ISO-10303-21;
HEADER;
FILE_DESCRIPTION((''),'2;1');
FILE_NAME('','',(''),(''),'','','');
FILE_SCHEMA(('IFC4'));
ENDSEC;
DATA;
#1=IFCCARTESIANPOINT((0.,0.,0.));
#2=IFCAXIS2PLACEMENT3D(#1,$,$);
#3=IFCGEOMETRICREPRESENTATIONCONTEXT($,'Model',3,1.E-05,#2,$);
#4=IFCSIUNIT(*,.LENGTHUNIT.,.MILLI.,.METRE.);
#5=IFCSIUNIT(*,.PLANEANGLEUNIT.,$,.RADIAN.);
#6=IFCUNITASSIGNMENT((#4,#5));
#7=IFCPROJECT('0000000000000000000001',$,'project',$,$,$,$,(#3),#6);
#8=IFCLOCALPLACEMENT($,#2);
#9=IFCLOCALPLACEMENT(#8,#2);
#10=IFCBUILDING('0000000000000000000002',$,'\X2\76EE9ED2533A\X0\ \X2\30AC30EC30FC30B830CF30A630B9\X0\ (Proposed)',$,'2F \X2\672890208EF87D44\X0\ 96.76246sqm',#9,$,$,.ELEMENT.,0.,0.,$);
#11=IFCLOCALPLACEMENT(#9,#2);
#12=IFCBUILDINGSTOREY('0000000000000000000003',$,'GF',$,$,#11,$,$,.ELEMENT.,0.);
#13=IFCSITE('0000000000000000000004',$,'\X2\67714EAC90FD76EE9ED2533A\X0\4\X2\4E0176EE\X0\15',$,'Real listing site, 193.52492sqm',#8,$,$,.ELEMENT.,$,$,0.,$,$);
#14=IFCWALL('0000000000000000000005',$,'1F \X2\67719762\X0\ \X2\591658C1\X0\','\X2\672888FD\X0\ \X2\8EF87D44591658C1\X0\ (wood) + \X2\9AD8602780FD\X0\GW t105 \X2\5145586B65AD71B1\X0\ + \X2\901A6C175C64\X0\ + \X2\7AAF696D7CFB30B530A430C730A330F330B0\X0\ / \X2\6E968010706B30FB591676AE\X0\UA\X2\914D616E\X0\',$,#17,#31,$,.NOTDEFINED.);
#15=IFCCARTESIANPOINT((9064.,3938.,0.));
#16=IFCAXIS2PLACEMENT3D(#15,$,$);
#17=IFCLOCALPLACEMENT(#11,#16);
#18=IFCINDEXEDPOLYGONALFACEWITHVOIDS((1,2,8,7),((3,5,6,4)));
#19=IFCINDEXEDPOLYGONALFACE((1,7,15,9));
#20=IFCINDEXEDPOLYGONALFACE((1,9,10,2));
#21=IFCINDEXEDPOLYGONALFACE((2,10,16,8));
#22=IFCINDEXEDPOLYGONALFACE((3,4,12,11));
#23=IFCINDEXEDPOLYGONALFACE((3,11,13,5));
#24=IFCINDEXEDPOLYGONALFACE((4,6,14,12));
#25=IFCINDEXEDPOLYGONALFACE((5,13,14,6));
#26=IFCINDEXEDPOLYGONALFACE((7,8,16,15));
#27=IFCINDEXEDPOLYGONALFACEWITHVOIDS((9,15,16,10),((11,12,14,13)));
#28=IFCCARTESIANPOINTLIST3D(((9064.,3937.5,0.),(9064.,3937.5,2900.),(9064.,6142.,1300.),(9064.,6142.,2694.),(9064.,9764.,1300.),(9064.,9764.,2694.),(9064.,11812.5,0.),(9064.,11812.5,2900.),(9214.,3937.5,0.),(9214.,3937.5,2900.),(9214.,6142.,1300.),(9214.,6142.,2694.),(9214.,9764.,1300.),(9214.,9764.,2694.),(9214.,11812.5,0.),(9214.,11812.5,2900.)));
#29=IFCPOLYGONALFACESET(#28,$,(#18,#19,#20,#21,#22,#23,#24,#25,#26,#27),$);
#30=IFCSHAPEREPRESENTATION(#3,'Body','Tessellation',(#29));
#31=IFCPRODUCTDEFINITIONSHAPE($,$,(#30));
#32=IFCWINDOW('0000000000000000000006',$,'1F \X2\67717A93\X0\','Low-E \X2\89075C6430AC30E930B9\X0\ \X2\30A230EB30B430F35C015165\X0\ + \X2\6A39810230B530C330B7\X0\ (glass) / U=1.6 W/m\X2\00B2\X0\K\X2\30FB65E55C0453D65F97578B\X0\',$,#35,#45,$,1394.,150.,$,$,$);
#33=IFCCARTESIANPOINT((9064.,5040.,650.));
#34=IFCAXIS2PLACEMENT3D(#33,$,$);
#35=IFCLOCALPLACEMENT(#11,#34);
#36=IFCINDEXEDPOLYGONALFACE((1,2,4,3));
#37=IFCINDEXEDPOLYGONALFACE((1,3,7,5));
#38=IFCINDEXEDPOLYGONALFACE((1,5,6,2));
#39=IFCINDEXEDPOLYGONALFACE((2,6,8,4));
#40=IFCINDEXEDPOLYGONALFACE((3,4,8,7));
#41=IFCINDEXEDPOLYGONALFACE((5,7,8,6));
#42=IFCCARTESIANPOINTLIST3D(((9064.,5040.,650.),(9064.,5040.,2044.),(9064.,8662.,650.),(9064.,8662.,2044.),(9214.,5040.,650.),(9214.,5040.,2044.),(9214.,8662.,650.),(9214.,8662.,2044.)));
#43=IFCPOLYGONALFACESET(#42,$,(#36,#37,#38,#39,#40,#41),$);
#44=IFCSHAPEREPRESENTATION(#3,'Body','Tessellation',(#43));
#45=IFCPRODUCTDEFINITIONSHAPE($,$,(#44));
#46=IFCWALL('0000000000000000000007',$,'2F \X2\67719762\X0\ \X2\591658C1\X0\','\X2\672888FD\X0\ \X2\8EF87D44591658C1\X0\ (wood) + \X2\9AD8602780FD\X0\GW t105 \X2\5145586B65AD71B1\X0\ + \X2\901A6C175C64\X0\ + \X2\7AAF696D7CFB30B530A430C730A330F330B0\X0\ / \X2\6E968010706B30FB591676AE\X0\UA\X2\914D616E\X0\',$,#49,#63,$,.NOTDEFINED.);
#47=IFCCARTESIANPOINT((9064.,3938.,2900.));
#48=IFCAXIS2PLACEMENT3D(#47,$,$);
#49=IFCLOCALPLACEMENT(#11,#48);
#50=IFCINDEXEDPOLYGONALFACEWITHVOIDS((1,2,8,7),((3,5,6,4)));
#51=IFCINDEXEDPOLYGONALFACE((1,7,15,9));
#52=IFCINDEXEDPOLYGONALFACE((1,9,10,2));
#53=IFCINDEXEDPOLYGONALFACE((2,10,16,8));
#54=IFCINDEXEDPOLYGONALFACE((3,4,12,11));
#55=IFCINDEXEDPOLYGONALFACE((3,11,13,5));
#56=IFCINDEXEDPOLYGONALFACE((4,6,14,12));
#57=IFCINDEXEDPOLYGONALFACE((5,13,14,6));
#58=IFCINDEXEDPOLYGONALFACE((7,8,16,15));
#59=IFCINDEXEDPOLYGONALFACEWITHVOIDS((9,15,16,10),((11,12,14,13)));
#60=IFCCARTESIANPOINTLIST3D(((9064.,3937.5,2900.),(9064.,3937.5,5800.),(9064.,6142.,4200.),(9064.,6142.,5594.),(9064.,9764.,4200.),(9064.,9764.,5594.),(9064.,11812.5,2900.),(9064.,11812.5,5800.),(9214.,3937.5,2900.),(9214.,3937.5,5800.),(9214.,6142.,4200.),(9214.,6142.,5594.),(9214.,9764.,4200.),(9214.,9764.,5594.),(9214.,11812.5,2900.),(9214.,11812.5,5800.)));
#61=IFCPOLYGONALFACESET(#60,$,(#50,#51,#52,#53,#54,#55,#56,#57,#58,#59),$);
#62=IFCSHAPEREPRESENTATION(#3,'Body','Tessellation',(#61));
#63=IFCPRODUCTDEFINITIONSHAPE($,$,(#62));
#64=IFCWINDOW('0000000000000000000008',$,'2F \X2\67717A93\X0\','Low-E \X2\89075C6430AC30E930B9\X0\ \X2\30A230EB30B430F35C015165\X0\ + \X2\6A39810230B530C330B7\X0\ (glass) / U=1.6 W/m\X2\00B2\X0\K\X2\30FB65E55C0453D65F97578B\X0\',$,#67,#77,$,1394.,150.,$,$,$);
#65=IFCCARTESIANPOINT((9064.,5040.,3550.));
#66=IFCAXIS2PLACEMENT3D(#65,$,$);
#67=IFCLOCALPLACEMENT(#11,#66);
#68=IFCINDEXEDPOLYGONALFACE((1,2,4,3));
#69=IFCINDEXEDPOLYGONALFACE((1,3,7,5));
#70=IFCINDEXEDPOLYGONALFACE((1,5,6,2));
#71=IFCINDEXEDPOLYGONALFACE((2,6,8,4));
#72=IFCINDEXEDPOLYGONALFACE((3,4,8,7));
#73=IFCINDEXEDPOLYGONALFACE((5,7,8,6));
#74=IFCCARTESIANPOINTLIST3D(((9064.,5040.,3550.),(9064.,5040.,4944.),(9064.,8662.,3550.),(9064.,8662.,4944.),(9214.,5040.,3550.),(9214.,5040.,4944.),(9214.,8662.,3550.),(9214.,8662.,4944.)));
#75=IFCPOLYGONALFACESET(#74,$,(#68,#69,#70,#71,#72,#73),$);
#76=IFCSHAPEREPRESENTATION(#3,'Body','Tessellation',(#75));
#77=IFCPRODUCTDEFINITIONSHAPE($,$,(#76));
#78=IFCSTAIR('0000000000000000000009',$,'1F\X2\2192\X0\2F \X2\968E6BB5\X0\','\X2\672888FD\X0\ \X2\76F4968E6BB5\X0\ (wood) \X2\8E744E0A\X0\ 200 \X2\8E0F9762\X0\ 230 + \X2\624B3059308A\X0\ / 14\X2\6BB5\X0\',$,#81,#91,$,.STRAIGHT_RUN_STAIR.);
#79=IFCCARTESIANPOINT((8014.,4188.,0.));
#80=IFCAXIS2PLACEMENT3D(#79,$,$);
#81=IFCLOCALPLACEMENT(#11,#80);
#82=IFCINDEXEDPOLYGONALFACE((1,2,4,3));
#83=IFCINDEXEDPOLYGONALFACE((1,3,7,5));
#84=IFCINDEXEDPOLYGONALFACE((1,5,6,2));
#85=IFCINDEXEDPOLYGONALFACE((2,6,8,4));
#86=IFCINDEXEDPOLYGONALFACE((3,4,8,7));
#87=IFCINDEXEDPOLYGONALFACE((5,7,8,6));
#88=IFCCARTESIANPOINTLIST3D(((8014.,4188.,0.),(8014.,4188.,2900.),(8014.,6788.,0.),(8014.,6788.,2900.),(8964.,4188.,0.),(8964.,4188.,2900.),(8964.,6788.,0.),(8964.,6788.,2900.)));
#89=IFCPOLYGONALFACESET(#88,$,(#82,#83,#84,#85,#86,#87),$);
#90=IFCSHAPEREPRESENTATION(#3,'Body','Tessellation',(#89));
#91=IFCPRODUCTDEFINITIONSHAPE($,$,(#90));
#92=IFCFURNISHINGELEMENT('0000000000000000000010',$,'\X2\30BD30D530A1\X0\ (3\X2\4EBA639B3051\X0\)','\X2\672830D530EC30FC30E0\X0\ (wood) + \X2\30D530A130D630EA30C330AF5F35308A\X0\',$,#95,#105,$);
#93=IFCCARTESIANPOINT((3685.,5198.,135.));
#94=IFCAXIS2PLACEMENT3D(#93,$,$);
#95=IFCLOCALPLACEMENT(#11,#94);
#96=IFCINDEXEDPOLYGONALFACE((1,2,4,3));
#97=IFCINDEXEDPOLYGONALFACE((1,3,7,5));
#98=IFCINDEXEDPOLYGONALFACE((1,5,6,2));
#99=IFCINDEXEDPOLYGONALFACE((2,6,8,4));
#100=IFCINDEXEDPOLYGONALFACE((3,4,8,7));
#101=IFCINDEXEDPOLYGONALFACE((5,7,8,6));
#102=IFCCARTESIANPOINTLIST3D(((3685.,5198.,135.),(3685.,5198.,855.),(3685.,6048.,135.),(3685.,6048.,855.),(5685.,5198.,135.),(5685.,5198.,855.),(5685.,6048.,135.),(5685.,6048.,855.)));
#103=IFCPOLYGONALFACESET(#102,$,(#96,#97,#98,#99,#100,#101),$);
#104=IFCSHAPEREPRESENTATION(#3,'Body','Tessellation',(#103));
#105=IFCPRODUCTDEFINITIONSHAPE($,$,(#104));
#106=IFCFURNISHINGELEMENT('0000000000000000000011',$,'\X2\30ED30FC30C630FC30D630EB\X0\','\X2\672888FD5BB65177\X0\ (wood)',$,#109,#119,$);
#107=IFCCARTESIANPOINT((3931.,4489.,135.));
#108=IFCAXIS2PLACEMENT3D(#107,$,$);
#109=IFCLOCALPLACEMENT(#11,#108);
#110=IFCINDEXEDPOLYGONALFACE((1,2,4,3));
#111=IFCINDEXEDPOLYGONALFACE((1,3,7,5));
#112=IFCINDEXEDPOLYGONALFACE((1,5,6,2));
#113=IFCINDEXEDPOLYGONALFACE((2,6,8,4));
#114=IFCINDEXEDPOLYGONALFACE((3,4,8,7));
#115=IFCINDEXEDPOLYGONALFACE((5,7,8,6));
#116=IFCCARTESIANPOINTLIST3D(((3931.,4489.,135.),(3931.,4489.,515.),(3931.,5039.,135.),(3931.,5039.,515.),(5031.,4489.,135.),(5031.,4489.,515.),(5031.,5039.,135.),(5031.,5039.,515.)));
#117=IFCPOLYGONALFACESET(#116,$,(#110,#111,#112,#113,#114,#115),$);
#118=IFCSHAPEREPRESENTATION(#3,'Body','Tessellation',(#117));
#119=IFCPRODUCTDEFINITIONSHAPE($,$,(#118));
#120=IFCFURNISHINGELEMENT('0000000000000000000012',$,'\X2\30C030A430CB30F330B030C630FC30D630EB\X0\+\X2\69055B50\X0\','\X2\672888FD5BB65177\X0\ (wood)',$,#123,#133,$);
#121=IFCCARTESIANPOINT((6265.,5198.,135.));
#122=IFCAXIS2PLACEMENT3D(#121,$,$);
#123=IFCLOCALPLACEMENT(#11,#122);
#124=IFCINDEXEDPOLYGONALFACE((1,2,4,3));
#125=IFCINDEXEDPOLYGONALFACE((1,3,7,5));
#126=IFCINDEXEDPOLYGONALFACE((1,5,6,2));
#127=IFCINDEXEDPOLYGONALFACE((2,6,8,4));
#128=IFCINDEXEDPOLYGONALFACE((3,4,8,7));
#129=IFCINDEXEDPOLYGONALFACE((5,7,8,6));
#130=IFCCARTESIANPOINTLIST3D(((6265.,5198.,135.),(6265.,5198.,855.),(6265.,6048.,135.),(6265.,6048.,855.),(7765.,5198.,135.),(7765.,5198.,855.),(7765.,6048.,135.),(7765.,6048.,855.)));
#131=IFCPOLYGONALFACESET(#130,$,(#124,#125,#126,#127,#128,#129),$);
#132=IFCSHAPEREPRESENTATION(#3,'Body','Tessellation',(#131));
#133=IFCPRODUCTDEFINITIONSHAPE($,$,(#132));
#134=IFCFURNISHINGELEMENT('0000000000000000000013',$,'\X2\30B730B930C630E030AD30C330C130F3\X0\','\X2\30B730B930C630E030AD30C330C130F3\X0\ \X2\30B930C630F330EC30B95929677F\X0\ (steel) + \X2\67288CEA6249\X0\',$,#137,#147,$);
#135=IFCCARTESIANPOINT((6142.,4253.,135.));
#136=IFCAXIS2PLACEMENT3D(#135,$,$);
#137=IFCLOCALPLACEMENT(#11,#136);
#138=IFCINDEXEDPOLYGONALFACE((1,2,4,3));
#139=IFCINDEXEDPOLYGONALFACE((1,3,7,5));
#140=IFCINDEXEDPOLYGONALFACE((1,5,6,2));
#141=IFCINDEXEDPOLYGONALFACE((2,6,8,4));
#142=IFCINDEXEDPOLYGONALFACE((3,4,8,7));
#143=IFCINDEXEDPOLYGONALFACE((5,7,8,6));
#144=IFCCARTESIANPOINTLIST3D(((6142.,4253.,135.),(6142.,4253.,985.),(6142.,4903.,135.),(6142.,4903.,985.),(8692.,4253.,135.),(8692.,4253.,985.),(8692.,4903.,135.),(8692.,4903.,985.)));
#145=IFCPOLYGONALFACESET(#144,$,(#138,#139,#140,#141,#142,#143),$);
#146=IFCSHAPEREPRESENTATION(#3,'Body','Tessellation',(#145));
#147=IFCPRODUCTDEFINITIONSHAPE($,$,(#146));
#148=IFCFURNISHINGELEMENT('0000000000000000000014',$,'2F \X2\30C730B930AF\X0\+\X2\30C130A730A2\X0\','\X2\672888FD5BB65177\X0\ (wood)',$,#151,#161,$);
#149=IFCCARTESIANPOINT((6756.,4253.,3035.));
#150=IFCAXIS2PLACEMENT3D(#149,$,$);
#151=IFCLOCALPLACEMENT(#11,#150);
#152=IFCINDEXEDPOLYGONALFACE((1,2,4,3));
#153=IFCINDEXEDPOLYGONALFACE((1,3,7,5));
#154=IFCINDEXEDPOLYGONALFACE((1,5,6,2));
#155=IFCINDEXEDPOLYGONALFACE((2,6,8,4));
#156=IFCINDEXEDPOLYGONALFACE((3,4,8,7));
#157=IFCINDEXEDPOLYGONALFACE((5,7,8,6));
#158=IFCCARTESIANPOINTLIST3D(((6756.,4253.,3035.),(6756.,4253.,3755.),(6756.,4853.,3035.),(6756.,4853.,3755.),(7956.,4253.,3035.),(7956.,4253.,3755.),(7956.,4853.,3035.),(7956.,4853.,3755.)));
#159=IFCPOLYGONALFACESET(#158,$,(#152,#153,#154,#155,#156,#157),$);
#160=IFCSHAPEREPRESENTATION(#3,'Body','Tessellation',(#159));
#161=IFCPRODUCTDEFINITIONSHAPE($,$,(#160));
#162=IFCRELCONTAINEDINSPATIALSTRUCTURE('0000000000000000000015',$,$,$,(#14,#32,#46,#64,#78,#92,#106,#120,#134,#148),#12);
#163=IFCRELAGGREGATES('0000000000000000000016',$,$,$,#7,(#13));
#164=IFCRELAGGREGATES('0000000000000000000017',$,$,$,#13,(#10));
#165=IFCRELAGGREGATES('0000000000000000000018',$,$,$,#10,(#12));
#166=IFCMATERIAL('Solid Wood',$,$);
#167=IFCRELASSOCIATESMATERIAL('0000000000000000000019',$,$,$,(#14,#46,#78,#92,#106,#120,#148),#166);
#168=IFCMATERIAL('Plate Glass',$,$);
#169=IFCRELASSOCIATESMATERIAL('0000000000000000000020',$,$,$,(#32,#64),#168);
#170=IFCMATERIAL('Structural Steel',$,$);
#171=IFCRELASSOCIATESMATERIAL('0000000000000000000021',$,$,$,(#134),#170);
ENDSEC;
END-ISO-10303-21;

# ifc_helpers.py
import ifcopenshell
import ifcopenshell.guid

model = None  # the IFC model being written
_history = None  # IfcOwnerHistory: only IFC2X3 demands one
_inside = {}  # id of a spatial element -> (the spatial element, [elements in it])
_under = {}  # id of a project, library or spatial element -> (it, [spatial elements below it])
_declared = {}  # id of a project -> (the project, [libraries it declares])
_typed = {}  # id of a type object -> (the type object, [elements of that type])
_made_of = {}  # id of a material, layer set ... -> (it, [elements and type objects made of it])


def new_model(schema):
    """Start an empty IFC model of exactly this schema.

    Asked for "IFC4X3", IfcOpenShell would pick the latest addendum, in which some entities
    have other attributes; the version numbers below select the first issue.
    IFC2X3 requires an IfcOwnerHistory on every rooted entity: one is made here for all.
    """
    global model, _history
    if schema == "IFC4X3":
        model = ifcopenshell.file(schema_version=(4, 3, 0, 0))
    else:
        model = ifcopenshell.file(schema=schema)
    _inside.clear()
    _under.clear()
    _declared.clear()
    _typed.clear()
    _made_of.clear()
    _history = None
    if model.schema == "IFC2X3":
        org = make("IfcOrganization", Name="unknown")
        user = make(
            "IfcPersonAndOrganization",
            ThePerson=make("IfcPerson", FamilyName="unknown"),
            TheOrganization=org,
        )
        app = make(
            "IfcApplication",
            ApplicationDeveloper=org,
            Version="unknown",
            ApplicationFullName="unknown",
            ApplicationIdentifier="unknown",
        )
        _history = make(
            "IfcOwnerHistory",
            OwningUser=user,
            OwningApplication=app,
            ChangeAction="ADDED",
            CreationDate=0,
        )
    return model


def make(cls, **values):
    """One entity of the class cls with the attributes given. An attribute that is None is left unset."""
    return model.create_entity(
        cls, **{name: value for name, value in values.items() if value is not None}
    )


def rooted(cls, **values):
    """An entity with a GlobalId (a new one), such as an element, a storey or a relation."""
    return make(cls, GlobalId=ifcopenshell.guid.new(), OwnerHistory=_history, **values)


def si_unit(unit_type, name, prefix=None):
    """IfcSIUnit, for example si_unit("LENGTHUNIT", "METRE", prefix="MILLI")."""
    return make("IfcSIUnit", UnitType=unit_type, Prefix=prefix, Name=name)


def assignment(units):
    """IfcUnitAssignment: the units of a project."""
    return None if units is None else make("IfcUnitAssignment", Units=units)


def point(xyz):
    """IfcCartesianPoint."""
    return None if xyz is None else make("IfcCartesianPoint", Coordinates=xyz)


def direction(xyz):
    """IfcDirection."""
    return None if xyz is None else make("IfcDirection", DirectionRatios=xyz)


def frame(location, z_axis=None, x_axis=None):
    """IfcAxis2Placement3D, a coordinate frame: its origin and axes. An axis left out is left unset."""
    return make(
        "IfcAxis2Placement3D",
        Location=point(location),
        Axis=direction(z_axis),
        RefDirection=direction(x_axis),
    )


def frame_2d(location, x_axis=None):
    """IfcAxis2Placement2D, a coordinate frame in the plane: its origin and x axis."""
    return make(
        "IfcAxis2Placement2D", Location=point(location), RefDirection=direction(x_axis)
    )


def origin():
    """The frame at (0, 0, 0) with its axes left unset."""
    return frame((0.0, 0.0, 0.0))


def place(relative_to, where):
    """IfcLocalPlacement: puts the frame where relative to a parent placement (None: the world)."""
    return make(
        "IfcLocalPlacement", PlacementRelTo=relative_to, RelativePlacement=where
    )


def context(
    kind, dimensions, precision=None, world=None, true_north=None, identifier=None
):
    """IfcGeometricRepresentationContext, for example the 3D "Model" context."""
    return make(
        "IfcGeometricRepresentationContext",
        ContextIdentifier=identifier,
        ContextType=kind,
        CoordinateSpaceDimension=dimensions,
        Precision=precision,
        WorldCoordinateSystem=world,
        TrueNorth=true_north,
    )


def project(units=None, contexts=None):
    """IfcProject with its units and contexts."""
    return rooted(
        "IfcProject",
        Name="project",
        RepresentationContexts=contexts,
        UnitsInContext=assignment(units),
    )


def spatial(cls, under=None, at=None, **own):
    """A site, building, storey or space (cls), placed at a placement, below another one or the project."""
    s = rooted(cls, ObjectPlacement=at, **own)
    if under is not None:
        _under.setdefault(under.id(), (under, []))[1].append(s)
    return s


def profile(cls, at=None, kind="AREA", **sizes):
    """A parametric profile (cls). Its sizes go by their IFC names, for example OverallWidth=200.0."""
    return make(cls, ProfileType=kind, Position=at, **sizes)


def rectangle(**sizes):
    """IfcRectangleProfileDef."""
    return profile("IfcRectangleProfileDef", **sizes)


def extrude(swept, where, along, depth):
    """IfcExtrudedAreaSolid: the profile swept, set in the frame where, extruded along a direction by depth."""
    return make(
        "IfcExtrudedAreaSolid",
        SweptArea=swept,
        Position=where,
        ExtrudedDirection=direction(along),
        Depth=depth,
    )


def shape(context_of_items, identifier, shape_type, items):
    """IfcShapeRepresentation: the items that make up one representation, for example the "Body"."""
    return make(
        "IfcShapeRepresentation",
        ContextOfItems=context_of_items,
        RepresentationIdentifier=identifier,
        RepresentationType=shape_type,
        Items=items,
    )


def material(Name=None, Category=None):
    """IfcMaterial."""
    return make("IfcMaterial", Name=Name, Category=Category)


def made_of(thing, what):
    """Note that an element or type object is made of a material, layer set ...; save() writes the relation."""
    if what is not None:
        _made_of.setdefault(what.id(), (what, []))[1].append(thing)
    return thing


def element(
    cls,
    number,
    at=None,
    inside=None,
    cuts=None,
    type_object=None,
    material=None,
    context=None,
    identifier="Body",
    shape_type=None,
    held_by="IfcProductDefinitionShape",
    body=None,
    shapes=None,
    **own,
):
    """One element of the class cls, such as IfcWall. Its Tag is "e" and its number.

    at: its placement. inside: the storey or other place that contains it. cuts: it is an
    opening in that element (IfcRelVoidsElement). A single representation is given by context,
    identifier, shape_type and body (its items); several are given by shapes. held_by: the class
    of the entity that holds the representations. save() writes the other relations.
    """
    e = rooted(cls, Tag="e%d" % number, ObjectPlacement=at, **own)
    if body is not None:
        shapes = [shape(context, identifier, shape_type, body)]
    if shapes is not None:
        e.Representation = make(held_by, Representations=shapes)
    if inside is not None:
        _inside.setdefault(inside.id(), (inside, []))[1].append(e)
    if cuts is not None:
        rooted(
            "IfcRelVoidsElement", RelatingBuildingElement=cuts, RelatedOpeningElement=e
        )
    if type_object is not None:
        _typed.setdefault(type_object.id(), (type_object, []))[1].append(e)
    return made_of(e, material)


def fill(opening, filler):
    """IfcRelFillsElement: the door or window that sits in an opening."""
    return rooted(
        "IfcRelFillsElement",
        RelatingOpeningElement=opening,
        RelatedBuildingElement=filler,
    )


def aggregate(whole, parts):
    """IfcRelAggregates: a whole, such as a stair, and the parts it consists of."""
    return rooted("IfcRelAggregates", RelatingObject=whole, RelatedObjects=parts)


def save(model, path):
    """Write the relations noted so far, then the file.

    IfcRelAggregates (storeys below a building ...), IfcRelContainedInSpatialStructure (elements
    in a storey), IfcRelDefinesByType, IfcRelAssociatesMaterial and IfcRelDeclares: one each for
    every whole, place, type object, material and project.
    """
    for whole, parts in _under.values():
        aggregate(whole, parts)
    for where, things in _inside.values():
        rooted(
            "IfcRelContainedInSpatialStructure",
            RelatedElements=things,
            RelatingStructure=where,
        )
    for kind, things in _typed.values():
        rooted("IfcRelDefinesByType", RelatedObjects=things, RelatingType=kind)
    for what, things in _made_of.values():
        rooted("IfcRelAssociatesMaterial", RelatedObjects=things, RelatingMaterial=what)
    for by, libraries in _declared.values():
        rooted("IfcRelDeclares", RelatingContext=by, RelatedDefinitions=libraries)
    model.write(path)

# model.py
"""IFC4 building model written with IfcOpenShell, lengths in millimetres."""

from ifc_helpers import new_model, si_unit, frame, frame_2d, origin, place, context, project, spatial, rectangle, extrude, material, element, fill, save


model = new_model("IFC4")

# Units and contexts
model_context = context("Model", 3, precision=1e-05, world=origin())
ifc_project = project(units=[si_unit("LENGTHUNIT", "METRE", prefix="MILLI"), si_unit("PLANEANGLEUNIT", "RADIAN")], contexts=[model_context])

# Site, building, storey
site_placement = place(None, origin())
site = spatial("IfcSite", under=ifc_project, at=site_placement, Name="東京都目黒区4丁目15", ObjectType="Real listing site, 193.52492sqm", CompositionType="ELEMENT", RefElevation=0.0)
building_placement = place(site_placement, origin())
building = spatial("IfcBuilding", under=site, at=building_placement, Name="目黒区 ガレージハウス (Proposed)", ObjectType="2F 木造軸組 96.76246sqm", CompositionType="ELEMENT", ElevationOfRefHeight=0.0, ElevationOfTerrain=0.0)
storey_placement = place(building_placement, origin())
storey = spatial("IfcBuildingStorey", under=building, at=storey_placement, Name="GF", CompositionType="ELEMENT", Elevation=0.0)

# Wall, opening, window
ifc_material_1 = material(Name="Solid Wood")
wall_1_placement = place(storey_placement, frame((9064.0, 3938.0, 0.0)))
wall_1 = element("IfcWall", 1, at=wall_1_placement, inside=storey, material=ifc_material_1, Name="1F 東面 外壁", Description="木製 軸組外壁 (wood) + 高性能GW t105 充填断熱 + 通気層 + 窯業系サイディング / 準耐火・外皮UA配慮", PredefinedType="NOTDEFINED", context=model_context, shape_type="SweptSolid", body=[
    extrude(rectangle(XDim=150.0, YDim=7875.0, at=frame_2d((75.0, 3937.0))), frame((9064.0, 3938.0, 0.0)), (0.0, 0.0, 1.0), 2900.0),
])
opening_1_placement = place(storey_placement, frame((9064.0, 5040.0, 650.0)))
opening_1 = element("IfcOpeningElement", 2, at=opening_1_placement, cuts=wall_1, PredefinedType="NOTDEFINED", context=model_context, shape_type="SweptSolid", body=[
    extrude(rectangle(XDim=150.0, YDim=3622.0, at=frame_2d((75.0, 1811.0))), frame((9064.0, 5040.0, 650.0)), (0.0, 0.0, 1.0), 1394.0),
])
ifc_material_2 = material(Name="Plate Glass")
window_1_placement = place(storey_placement, frame((9064.0, 5040.0, 650.0)))
window_1 = element("IfcWindow", 3, at=window_1_placement, inside=storey, material=ifc_material_2, Name="1F 東窓", Description="Low-E 複層ガラス アルゴン封入 + 樹脂サッシ (glass) / U=1.6 W/m²K・日射取得型", OverallHeight=1394.0, OverallWidth=150.0, context=model_context, shape_type="SweptSolid", body=[
    extrude(rectangle(XDim=150.0, YDim=3622.0, at=frame_2d((75.0, 1811.0))), frame((9064.0, 5040.0, 650.0)), (0.0, 0.0, 1.0), 1394.0),
])
fill(opening_1, window_1)

# Wall, opening, window
wall_2_placement = place(storey_placement, frame((9064.0, 3938.0, 2900.0)))
wall_2 = element("IfcWall", 4, at=wall_2_placement, inside=storey, material=ifc_material_1, Name="2F 東面 外壁", Description="木製 軸組外壁 (wood) + 高性能GW t105 充填断熱 + 通気層 + 窯業系サイディング / 準耐火・外皮UA配慮", PredefinedType="NOTDEFINED", context=model_context, shape_type="SweptSolid", body=[
    extrude(rectangle(XDim=150.0, YDim=7875.0, at=frame_2d((75.0, 3937.0))), frame((9064.0, 3938.0, 2900.0)), (0.0, 0.0, 1.0), 2900.0),
])
opening_2_placement = place(storey_placement, frame((9064.0, 5040.0, 3550.0)))
opening_2 = element("IfcOpeningElement", 5, at=opening_2_placement, cuts=wall_2, PredefinedType="NOTDEFINED", context=model_context, shape_type="SweptSolid", body=[
    extrude(rectangle(XDim=150.0, YDim=3622.0, at=frame_2d((75.0, 1811.0))), frame((9064.0, 5040.0, 3550.0)), (0.0, 0.0, 1.0), 1394.0),
])
window_2_placement = place(storey_placement, frame((9064.0, 5040.0, 3550.0)))
window_2 = element("IfcWindow", 6, at=window_2_placement, inside=storey, material=ifc_material_2, Name="2F 東窓", Description="Low-E 複層ガラス アルゴン封入 + 樹脂サッシ (glass) / U=1.6 W/m²K・日射取得型", OverallHeight=1394.0, OverallWidth=150.0, context=model_context, shape_type="SweptSolid", body=[
    extrude(rectangle(XDim=150.0, YDim=3622.0, at=frame_2d((75.0, 1811.0))), frame((9064.0, 5040.0, 3550.0)), (0.0, 0.0, 1.0), 1394.0),
])
fill(opening_2, window_2)

# Stair
stair_placement = place(storey_placement, frame((8014.0, 4188.0, 0.0)))
element("IfcStair", 7, at=stair_placement, inside=storey, material=ifc_material_1, Name="1F→2F 階段", Description="木製 直階段 (wood) 蹴上 200 踏面 230 + 手すり / 14段", PredefinedType="STRAIGHT_RUN_STAIR", context=model_context, shape_type="SweptSolid", body=[
    extrude(rectangle(XDim=950.0, YDim=2600.0, at=frame_2d((475.0, 1300.0))), frame((8014.0, 4188.0, 0.0)), (0.0, 0.0, 1.0), 2900.0),
])

# Furnishing elements
furnishing_1_placement = place(storey_placement, frame((3685.0, 5198.0, 135.0)))
element("IfcFurnishingElement", 8, at=furnishing_1_placement, inside=storey, material=ifc_material_1, Name="ソファ (3人掛け)", Description="木フレーム (wood) + ファブリック張り", context=model_context, shape_type="SweptSolid", body=[
    extrude(rectangle(XDim=2000.0, YDim=850.0, at=frame_2d((1000.0, 425.0))), frame((3685.0, 5198.0, 135.0)), (0.0, 0.0, 1.0), 720.0),
])
furnishing_2_placement = place(storey_placement, frame((3931.0, 4489.0, 135.0)))
element("IfcFurnishingElement", 9, at=furnishing_2_placement, inside=storey, material=ifc_material_1, Name="ローテーブル", Description="木製家具 (wood)", context=model_context, shape_type="SweptSolid", body=[
    extrude(rectangle(XDim=1100.0, YDim=550.0, at=frame_2d((550.0, 275.0))), frame((3931.0, 4489.0, 135.0)), (0.0, 0.0, 1.0), 380.0),
])
furnishing_3_placement = place(storey_placement, frame((6265.0, 5198.0, 135.0)))
element("IfcFurnishingElement", 10, at=furnishing_3_placement, inside=storey, material=ifc_material_1, Name="ダイニングテーブル+椅子", Description="木製家具 (wood)", context=model_context, shape_type="SweptSolid", body=[
    extrude(rectangle(XDim=1500.0, YDim=850.0, at=frame_2d((750.0, 425.0))), frame((6265.0, 5198.0, 135.0)), (0.0, 0.0, 1.0), 720.0),
])
ifc_material_3 = material(Name="Structural Steel")
furnishing_4_placement = place(storey_placement, frame((6142.0, 4253.0, 135.0)))
element("IfcFurnishingElement", 11, at=furnishing_4_placement, inside=storey, material=ifc_material_3, Name="システムキッチン", Description="システムキッチン ステンレス天板 (steel) + 木質扉", context=model_context, shape_type="SweptSolid", body=[
    extrude(rectangle(XDim=2550.0, YDim=650.0, at=frame_2d((1275.0, 325.0))), frame((6142.0, 4253.0, 135.0)), (0.0, 0.0, 1.0), 850.0),
])
furnishing_5_placement = place(storey_placement, frame((6756.0, 4253.0, 3035.0)))
element("IfcFurnishingElement", 12, at=furnishing_5_placement, inside=storey, material=ifc_material_1, Name="2F デスク+チェア", Description="木製家具 (wood)", context=model_context, shape_type="SweptSolid", body=[
    extrude(rectangle(XDim=1200.0, YDim=600.0, at=frame_2d((600.0, 300.0))), frame((6756.0, 4253.0, 3035.0)), (0.0, 0.0, 1.0), 720.0),
])

save(model, "model.ifc")
